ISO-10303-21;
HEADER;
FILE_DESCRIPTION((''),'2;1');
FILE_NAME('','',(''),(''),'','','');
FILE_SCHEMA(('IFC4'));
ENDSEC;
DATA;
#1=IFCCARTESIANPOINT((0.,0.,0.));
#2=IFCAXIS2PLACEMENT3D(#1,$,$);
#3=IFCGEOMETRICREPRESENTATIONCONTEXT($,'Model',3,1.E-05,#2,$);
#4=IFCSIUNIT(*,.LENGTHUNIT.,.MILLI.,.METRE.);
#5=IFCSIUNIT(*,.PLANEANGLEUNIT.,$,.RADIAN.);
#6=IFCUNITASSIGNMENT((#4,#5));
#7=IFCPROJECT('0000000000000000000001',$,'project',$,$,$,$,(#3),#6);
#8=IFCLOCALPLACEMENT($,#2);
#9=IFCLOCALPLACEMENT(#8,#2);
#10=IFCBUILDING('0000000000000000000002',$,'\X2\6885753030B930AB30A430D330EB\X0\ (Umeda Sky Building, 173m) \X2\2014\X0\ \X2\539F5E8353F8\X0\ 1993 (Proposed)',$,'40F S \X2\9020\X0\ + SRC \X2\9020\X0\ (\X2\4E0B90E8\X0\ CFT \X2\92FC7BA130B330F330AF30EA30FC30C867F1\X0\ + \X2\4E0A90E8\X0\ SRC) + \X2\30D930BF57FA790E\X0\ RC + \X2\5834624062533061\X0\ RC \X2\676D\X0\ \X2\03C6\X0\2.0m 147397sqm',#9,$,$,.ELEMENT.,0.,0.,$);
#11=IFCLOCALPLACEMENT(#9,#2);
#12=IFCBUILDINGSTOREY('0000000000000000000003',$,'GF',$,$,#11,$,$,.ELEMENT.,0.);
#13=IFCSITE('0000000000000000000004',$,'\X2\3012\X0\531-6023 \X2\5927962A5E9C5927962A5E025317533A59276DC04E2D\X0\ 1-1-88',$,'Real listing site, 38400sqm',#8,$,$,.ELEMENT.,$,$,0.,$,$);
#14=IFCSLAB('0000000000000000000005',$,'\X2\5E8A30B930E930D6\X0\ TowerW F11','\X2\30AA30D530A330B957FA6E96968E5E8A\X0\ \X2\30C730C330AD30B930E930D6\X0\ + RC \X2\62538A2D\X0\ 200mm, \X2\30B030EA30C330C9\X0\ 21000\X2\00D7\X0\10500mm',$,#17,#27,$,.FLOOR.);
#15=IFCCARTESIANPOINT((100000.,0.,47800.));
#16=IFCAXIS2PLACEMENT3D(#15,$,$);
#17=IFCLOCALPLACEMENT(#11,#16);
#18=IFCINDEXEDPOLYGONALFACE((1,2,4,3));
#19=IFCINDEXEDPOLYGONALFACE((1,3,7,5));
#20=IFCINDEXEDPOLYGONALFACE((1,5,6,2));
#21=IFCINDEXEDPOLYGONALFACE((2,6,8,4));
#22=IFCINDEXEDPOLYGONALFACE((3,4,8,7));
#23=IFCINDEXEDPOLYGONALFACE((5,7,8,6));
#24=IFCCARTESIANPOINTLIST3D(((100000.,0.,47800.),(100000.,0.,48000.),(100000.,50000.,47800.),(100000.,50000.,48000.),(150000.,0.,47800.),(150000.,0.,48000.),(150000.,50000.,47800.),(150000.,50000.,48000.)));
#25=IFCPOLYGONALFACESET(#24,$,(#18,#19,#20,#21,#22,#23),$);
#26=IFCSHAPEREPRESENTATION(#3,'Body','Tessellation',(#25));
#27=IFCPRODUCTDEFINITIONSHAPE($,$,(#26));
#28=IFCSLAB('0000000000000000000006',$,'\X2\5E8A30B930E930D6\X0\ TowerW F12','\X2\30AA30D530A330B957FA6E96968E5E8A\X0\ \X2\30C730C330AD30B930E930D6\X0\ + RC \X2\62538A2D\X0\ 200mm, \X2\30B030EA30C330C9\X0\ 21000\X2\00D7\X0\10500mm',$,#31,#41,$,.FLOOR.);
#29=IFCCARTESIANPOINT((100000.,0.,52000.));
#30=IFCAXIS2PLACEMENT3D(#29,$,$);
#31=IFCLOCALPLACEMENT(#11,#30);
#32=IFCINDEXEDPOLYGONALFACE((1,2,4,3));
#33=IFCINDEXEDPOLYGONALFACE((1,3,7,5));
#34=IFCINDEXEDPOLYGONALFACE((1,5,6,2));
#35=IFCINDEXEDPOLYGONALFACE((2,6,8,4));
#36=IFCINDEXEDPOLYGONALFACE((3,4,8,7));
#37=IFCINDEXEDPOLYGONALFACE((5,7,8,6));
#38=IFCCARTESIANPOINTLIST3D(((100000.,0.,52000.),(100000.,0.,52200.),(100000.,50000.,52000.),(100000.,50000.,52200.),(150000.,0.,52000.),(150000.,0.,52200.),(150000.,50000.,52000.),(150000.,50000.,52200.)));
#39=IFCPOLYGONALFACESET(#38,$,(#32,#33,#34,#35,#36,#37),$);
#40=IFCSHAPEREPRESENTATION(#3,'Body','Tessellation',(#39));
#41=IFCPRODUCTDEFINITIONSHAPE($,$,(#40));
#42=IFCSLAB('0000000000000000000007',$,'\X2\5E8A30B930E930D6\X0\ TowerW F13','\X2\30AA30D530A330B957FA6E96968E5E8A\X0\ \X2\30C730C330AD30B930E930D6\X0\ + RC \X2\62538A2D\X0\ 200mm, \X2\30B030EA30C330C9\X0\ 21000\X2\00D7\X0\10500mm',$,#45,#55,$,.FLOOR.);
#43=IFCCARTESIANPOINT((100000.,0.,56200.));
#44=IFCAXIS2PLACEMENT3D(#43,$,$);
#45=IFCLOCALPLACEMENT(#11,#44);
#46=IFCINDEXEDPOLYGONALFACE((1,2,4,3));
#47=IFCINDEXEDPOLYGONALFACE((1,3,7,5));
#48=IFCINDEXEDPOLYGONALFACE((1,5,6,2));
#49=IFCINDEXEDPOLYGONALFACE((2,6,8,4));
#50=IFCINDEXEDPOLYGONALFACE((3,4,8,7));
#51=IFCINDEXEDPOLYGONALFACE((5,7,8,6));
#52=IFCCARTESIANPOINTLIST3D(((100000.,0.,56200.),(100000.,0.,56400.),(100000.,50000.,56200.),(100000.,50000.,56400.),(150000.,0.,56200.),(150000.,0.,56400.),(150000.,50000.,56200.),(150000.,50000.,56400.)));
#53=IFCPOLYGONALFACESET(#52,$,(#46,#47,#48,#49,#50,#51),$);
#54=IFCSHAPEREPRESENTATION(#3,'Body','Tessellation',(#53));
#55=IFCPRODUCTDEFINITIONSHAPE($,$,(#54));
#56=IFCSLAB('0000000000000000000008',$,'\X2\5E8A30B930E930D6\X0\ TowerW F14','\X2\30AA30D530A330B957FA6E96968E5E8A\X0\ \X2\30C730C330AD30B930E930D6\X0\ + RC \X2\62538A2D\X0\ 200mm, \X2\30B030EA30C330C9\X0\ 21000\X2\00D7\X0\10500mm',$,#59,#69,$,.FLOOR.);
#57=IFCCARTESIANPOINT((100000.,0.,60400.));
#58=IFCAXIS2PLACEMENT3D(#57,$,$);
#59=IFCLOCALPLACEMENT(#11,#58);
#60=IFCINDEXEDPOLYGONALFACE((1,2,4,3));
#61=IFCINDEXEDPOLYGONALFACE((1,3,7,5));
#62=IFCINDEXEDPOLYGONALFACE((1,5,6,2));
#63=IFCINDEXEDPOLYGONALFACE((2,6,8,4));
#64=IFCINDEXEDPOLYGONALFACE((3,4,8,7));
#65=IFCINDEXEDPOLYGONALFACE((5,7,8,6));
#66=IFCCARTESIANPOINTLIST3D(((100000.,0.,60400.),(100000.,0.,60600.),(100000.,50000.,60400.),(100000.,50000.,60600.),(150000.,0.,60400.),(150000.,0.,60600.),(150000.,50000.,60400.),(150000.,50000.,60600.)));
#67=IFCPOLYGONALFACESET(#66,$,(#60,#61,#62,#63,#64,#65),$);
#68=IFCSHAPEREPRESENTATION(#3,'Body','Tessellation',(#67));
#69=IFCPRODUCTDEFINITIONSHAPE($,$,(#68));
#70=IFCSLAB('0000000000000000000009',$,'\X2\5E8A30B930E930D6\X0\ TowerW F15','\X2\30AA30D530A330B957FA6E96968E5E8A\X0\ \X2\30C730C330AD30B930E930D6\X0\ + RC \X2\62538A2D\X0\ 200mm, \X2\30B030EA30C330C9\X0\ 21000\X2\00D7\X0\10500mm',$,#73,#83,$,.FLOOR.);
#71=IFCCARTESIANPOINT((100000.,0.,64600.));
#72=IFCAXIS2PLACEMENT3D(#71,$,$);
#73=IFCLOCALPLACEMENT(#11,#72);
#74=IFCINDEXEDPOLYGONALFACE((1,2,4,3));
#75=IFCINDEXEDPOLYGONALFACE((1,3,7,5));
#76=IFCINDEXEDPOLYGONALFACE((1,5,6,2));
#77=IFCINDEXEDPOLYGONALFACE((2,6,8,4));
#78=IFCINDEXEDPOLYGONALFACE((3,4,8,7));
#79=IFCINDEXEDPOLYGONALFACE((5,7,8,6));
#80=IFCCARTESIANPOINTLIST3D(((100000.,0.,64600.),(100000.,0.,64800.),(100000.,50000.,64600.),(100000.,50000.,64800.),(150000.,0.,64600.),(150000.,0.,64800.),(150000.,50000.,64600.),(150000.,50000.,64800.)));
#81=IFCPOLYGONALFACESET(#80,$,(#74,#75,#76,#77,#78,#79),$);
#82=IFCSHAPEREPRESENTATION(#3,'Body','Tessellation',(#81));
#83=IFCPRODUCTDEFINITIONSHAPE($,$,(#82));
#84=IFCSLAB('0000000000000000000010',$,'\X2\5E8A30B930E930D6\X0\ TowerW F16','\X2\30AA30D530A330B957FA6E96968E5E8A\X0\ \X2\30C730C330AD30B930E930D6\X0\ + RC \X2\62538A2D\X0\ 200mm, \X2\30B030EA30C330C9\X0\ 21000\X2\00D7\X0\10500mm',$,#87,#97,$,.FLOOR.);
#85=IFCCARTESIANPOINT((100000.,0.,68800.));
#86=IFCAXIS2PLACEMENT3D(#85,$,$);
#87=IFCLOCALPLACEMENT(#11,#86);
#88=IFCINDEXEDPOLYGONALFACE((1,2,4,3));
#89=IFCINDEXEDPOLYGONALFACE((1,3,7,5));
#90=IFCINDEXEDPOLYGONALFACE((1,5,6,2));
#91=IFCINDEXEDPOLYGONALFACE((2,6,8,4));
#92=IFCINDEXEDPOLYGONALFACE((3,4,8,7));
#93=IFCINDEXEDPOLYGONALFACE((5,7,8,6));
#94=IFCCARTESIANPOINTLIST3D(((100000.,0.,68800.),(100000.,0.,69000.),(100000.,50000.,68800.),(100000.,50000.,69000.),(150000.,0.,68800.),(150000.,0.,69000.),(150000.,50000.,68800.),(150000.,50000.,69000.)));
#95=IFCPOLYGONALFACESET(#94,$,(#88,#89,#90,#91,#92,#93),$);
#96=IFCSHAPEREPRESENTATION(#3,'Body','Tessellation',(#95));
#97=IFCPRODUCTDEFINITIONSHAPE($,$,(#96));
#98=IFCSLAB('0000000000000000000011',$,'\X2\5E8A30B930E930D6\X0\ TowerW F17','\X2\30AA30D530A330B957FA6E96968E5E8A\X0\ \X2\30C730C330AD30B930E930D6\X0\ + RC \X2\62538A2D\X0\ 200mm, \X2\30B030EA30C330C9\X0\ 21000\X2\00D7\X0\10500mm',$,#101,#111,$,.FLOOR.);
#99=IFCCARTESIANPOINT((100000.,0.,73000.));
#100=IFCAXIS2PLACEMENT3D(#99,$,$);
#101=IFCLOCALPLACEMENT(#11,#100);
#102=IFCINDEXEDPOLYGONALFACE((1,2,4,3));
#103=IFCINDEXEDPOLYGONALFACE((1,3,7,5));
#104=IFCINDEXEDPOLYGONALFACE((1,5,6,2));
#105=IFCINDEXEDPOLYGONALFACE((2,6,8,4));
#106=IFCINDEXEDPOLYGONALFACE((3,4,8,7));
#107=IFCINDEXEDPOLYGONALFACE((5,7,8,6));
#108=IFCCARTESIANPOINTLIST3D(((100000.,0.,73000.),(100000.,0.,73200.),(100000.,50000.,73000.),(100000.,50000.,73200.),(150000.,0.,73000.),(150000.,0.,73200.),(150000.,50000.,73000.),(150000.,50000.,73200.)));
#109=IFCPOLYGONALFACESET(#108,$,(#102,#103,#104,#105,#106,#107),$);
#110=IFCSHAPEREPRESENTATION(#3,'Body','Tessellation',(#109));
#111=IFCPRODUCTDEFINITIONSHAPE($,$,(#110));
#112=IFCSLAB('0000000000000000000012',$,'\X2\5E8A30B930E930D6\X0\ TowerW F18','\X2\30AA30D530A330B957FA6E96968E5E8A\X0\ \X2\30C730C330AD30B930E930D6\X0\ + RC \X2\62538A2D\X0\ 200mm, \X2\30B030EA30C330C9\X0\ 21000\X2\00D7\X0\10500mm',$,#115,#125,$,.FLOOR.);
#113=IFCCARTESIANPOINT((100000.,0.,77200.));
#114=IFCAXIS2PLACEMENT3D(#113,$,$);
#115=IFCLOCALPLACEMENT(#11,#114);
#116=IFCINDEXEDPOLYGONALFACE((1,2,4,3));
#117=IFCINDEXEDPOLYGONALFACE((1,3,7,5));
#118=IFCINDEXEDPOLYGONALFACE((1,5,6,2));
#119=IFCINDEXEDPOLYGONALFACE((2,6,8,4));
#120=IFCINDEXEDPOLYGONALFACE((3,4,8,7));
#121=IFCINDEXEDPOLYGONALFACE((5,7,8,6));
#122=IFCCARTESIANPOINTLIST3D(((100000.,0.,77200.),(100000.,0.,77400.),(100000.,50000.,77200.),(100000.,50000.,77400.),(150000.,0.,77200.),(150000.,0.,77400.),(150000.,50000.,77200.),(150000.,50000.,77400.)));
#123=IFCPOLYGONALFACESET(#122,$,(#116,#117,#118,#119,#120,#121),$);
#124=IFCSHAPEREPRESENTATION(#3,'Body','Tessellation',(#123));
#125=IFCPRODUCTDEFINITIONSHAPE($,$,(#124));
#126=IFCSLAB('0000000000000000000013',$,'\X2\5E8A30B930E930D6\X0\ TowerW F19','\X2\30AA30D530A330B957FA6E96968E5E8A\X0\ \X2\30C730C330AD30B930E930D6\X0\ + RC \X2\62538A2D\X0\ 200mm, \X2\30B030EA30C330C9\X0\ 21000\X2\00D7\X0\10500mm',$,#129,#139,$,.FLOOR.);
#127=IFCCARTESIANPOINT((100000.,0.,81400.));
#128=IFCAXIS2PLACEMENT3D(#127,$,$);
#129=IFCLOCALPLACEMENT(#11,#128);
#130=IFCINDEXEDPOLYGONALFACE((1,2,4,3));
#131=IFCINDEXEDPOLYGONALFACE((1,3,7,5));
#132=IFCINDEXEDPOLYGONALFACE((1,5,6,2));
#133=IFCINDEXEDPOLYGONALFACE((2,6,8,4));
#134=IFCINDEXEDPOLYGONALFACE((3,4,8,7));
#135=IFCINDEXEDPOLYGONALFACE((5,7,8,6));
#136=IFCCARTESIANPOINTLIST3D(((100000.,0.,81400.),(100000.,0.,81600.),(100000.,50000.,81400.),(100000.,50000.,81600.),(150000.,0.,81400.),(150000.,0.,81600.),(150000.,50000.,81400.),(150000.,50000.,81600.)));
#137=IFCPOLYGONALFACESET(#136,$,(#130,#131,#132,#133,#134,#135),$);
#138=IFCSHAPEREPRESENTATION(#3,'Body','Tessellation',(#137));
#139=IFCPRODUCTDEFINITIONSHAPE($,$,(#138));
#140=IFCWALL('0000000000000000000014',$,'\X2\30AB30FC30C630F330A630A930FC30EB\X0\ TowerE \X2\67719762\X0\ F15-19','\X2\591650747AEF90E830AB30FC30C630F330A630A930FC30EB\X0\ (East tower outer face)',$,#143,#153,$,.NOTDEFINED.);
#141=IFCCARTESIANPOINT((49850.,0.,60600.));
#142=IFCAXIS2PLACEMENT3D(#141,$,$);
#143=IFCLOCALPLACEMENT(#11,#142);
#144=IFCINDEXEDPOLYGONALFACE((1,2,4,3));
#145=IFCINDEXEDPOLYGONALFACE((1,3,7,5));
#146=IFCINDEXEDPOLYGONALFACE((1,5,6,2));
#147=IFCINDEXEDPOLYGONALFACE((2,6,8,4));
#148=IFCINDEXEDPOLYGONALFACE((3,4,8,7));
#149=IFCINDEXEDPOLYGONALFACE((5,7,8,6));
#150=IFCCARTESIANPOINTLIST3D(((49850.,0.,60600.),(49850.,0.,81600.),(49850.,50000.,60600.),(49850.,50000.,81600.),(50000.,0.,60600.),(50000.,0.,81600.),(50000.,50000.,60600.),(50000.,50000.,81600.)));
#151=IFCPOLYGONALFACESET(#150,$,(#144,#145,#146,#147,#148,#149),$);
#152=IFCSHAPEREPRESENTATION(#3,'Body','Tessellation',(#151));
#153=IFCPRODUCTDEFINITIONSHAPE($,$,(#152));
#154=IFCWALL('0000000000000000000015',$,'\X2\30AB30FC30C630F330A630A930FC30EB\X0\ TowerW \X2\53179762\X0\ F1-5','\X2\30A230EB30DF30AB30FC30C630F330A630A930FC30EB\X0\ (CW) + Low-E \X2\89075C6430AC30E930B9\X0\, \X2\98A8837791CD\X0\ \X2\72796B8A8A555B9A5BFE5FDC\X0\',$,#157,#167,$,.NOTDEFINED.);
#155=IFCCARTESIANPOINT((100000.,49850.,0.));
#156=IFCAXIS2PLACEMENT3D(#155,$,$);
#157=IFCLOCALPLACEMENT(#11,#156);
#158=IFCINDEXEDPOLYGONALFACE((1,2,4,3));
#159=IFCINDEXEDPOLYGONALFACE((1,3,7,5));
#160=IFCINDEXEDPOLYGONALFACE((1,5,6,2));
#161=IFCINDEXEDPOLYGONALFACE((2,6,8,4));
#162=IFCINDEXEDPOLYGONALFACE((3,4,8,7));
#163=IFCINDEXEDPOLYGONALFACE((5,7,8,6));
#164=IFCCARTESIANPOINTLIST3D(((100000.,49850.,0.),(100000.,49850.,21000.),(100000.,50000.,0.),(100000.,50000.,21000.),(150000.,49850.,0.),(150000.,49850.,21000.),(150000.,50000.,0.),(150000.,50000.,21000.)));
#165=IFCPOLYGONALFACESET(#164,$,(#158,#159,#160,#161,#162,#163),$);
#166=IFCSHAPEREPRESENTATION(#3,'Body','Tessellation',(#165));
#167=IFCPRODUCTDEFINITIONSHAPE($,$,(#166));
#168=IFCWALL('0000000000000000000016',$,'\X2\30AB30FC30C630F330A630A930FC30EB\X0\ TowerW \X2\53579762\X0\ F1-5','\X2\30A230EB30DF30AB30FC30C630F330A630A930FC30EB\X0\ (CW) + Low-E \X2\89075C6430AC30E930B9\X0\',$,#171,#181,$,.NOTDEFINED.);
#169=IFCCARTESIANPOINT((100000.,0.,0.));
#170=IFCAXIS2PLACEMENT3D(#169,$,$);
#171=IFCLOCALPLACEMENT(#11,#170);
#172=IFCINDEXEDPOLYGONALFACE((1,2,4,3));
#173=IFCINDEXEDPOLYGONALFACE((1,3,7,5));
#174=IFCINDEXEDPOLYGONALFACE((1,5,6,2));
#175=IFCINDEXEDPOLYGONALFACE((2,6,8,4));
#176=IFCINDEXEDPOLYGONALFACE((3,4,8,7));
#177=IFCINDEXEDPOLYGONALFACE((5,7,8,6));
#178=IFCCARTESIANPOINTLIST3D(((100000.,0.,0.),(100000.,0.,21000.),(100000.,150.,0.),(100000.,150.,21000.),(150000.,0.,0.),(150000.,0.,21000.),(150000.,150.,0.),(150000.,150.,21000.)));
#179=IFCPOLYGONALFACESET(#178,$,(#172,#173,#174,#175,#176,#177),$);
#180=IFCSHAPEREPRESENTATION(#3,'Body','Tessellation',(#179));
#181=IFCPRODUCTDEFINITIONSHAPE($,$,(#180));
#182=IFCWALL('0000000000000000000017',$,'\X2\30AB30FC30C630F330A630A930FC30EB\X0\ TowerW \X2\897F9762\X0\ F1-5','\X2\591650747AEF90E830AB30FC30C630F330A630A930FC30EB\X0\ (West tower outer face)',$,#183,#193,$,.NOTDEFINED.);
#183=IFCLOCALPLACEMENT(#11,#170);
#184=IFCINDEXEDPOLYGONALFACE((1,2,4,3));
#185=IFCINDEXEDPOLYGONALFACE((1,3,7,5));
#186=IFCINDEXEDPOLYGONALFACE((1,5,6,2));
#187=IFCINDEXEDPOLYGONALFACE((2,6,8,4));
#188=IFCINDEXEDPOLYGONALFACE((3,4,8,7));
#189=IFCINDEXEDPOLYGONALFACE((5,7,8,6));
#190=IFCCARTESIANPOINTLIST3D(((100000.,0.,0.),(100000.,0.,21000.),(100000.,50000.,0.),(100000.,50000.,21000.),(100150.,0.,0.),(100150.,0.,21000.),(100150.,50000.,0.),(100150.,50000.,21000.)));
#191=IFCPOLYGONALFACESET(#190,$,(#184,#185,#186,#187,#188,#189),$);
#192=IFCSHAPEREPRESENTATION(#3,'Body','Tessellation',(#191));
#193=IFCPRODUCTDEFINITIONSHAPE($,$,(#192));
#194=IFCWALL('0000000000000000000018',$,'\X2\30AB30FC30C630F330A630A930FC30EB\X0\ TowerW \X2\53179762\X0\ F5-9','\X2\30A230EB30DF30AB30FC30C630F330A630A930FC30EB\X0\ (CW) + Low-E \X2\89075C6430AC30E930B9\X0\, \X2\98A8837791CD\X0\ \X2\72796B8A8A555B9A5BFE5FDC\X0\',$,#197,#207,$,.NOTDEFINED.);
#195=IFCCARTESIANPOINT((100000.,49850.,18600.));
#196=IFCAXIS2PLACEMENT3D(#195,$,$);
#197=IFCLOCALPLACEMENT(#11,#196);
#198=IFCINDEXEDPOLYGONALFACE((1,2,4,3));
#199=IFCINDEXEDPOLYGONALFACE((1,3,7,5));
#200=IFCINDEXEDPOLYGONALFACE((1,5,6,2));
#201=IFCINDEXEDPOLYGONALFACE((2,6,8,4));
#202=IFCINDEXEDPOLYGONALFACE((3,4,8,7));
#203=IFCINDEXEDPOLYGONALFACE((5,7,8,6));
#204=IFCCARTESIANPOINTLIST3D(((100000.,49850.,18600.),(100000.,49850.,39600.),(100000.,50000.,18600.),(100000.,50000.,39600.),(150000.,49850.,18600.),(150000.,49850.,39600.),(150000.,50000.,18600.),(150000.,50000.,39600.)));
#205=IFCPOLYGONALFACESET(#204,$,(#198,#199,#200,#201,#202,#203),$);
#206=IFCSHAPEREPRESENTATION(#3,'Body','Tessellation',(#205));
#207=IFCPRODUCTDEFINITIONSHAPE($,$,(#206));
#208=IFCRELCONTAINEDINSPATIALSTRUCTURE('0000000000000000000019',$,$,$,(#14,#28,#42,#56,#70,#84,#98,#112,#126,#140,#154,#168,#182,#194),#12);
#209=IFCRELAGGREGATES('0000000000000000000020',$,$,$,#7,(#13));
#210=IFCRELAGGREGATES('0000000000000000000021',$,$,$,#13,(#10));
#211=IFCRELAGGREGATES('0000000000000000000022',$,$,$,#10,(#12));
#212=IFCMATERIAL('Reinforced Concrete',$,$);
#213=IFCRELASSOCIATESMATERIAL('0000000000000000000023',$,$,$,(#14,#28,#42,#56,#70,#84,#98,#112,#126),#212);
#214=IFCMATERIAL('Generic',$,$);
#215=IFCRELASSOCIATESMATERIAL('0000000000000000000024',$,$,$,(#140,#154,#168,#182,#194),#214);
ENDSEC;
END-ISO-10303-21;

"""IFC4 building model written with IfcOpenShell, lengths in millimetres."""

from ifc_helpers import new_model, si_unit, frame, frame_2d, origin, place, context, project, spatial, rectangle, extrude, material, element, save


model = new_model("IFC4")

# Units and contexts
model_context = context("Model", 3, precision=1e-05, world=origin())
ifc_project = project(units=[si_unit("LENGTHUNIT", "METRE", prefix="MILLI"), si_unit("PLANEANGLEUNIT", "RADIAN")], contexts=[model_context])

# Site, building, storey
site_placement = place(None, origin())
site = spatial("IfcSite", under=ifc_project, at=site_placement, Name="〒531-6023 大阪府大阪市北区大淀中 1-1-88", ObjectType="Real listing site, 38400sqm", CompositionType="ELEMENT", RefElevation=0.0)
building_placement = place(site_placement, origin())
building = spatial("IfcBuilding", under=site, at=building_placement, Name="梅田スカイビル (Umeda Sky Building, 173m) — 原広司 1993 (Proposed)", ObjectType="40F S 造 + SRC 造 (下部 CFT 鋼管コンクリート柱 + 上部 SRC) + ベタ基礎 RC + 場所打ち RC 杭 φ2.0m 147397sqm", CompositionType="ELEMENT", ElevationOfRefHeight=0.0, ElevationOfTerrain=0.0)
storey_placement = place(building_placement, origin())
storey = spatial("IfcBuildingStorey", under=building, at=storey_placement, Name="GF", CompositionType="ELEMENT", Elevation=0.0)

# Shared definitions
ifc_material_1 = material(Name="Reinforced Concrete")

# Slabs
slab_1_placement = place(storey_placement, frame((100000.0, 0.0, 47800.0)))
element("IfcSlab", 1, at=slab_1_placement, inside=storey, material=ifc_material_1, Name="床スラブ TowerW F11", Description="オフィス基準階床 デッキスラブ + RC 打設 200mm, グリッド 21000×10500mm", PredefinedType="FLOOR", context=model_context, shape_type="SweptSolid", body=[
    extrude(rectangle(XDim=50000.0, YDim=50000.0, at=frame_2d((25000.0, 25000.0))), frame((100000.0, 0.0, 47800.0)), (0.0, 0.0, 1.0), 200.0),
])
slab_2_placement = place(storey_placement, frame((100000.0, 0.0, 52000.0)))
element("IfcSlab", 2, at=slab_2_placement, inside=storey, material=ifc_material_1, Name="床スラブ TowerW F12", Description="オフィス基準階床 デッキスラブ + RC 打設 200mm, グリッド 21000×10500mm", PredefinedType="FLOOR", context=model_context, shape_type="SweptSolid", body=[
    extrude(rectangle(XDim=50000.0, YDim=50000.0, at=frame_2d((25000.0, 25000.0))), frame((100000.0, 0.0, 52000.0)), (0.0, 0.0, 1.0), 200.0),
])
slab_3_placement = place(storey_placement, frame((100000.0, 0.0, 56200.0)))
element("IfcSlab", 3, at=slab_3_placement, inside=storey, material=ifc_material_1, Name="床スラブ TowerW F13", Description="オフィス基準階床 デッキスラブ + RC 打設 200mm, グリッド 21000×10500mm", PredefinedType="FLOOR", context=model_context, shape_type="SweptSolid", body=[
    extrude(rectangle(XDim=50000.0, YDim=50000.0, at=frame_2d((25000.0, 25000.0))), frame((100000.0, 0.0, 56200.0)), (0.0, 0.0, 1.0), 200.0),
])
slab_4_placement = place(storey_placement, frame((100000.0, 0.0, 60400.0)))
element("IfcSlab", 4, at=slab_4_placement, inside=storey, material=ifc_material_1, Name="床スラブ TowerW F14", Description="オフィス基準階床 デッキスラブ + RC 打設 200mm, グリッド 21000×10500mm", PredefinedType="FLOOR", context=model_context, shape_type="SweptSolid", body=[
    extrude(rectangle(XDim=50000.0, YDim=50000.0, at=frame_2d((25000.0, 25000.0))), frame((100000.0, 0.0, 60400.0)), (0.0, 0.0, 1.0), 200.0),
])
slab_5_placement = place(storey_placement, frame((100000.0, 0.0, 64600.0)))
element("IfcSlab", 5, at=slab_5_placement, inside=storey, material=ifc_material_1, Name="床スラブ TowerW F15", Description="オフィス基準階床 デッキスラブ + RC 打設 200mm, グリッド 21000×10500mm", PredefinedType="FLOOR", context=model_context, shape_type="SweptSolid", body=[
    extrude(rectangle(XDim=50000.0, YDim=50000.0, at=frame_2d((25000.0, 25000.0))), frame((100000.0, 0.0, 64600.0)), (0.0, 0.0, 1.0), 200.0),
])
slab_6_placement = place(storey_placement, frame((100000.0, 0.0, 68800.0)))
element("IfcSlab", 6, at=slab_6_placement, inside=storey, material=ifc_material_1, Name="床スラブ TowerW F16", Description="オフィス基準階床 デッキスラブ + RC 打設 200mm, グリッド 21000×10500mm", PredefinedType="FLOOR", context=model_context, shape_type="SweptSolid", body=[
    extrude(rectangle(XDim=50000.0, YDim=50000.0, at=frame_2d((25000.0, 25000.0))), frame((100000.0, 0.0, 68800.0)), (0.0, 0.0, 1.0), 200.0),
])
slab_7_placement = place(storey_placement, frame((100000.0, 0.0, 73000.0)))
element("IfcSlab", 7, at=slab_7_placement, inside=storey, material=ifc_material_1, Name="床スラブ TowerW F17", Description="オフィス基準階床 デッキスラブ + RC 打設 200mm, グリッド 21000×10500mm", PredefinedType="FLOOR", context=model_context, shape_type="SweptSolid", body=[
    extrude(rectangle(XDim=50000.0, YDim=50000.0, at=frame_2d((25000.0, 25000.0))), frame((100000.0, 0.0, 73000.0)), (0.0, 0.0, 1.0), 200.0),
])
slab_8_placement = place(storey_placement, frame((100000.0, 0.0, 77200.0)))
element("IfcSlab", 8, at=slab_8_placement, inside=storey, material=ifc_material_1, Name="床スラブ TowerW F18", Description="オフィス基準階床 デッキスラブ + RC 打設 200mm, グリッド 21000×10500mm", PredefinedType="FLOOR", context=model_context, shape_type="SweptSolid", body=[
    extrude(rectangle(XDim=50000.0, YDim=50000.0, at=frame_2d((25000.0, 25000.0))), frame((100000.0, 0.0, 77200.0)), (0.0, 0.0, 1.0), 200.0),
])
slab_9_placement = place(storey_placement, frame((100000.0, 0.0, 81400.0)))
element("IfcSlab", 9, at=slab_9_placement, inside=storey, material=ifc_material_1, Name="床スラブ TowerW F19", Description="オフィス基準階床 デッキスラブ + RC 打設 200mm, グリッド 21000×10500mm", PredefinedType="FLOOR", context=model_context, shape_type="SweptSolid", body=[
    extrude(rectangle(XDim=50000.0, YDim=50000.0, at=frame_2d((25000.0, 25000.0))), frame((100000.0, 0.0, 81400.0)), (0.0, 0.0, 1.0), 200.0),
])

# Walls
ifc_material_2 = material(Name="Generic")
wall_1_placement = place(storey_placement, frame((49850.0, 0.0, 60600.0)))
element("IfcWall", 10, at=wall_1_placement, inside=storey, material=ifc_material_2, Name="カーテンウォール TowerE 東面 F15-19", Description="外側端部カーテンウォール (East tower outer face)", PredefinedType="NOTDEFINED", context=model_context, shape_type="SweptSolid", body=[
    extrude(rectangle(XDim=150.0, YDim=50000.0, at=frame_2d((75.0, 25000.0))), frame((49850.0, 0.0, 60600.0)), (0.0, 0.0, 1.0), 21000.0),
])
wall_2_placement = place(storey_placement, frame((100000.0, 49850.0, 0.0)))
element("IfcWall", 11, at=wall_2_placement, inside=storey, material=ifc_material_2, Name="カーテンウォール TowerW 北面 F1-5", Description="アルミカーテンウォール (CW) + Low-E 複層ガラス, 風荷重 特殊評定対応", PredefinedType="NOTDEFINED", context=model_context, shape_type="SweptSolid", body=[
    extrude(rectangle(XDim=50000.0, YDim=150.0, at=frame_2d((25000.0, 75.0))), frame((100000.0, 49850.0, 0.0)), (0.0, 0.0, 1.0), 21000.0),
])
wall_3_placement = place(storey_placement, frame((100000.0, 0.0, 0.0)))
element("IfcWall", 12, at=wall_3_placement, inside=storey, material=ifc_material_2, Name="カーテンウォール TowerW 南面 F1-5", Description="アルミカーテンウォール (CW) + Low-E 複層ガラス", PredefinedType="NOTDEFINED", context=model_context, shape_type="SweptSolid", body=[
    extrude(rectangle(XDim=50000.0, YDim=150.0, at=frame_2d((25000.0, 75.0))), frame((100000.0, 0.0, 0.0)), (0.0, 0.0, 1.0), 21000.0),
])
wall_4_placement = place(storey_placement, frame((100000.0, 0.0, 0.0)))
element("IfcWall", 13, at=wall_4_placement, inside=storey, material=ifc_material_2, Name="カーテンウォール TowerW 西面 F1-5", Description="外側端部カーテンウォール (West tower outer face)", PredefinedType="NOTDEFINED", context=model_context, shape_type="SweptSolid", body=[
    extrude(rectangle(XDim=150.0, YDim=50000.0, at=frame_2d((75.0, 25000.0))), frame((100000.0, 0.0, 0.0)), (0.0, 0.0, 1.0), 21000.0),
])
wall_5_placement = place(storey_placement, frame((100000.0, 49850.0, 18600.0)))
element("IfcWall", 14, at=wall_5_placement, inside=storey, material=ifc_material_2, Name="カーテンウォール TowerW 北面 F5-9", Description="アルミカーテンウォール (CW) + Low-E 複層ガラス, 風荷重 特殊評定対応", PredefinedType="NOTDEFINED", context=model_context, shape_type="SweptSolid", body=[
    extrude(rectangle(XDim=50000.0, YDim=150.0, at=frame_2d((25000.0, 75.0))), frame((100000.0, 49850.0, 18600.0)), (0.0, 0.0, 1.0), 21000.0),
])

save(model, "model.ifc")
